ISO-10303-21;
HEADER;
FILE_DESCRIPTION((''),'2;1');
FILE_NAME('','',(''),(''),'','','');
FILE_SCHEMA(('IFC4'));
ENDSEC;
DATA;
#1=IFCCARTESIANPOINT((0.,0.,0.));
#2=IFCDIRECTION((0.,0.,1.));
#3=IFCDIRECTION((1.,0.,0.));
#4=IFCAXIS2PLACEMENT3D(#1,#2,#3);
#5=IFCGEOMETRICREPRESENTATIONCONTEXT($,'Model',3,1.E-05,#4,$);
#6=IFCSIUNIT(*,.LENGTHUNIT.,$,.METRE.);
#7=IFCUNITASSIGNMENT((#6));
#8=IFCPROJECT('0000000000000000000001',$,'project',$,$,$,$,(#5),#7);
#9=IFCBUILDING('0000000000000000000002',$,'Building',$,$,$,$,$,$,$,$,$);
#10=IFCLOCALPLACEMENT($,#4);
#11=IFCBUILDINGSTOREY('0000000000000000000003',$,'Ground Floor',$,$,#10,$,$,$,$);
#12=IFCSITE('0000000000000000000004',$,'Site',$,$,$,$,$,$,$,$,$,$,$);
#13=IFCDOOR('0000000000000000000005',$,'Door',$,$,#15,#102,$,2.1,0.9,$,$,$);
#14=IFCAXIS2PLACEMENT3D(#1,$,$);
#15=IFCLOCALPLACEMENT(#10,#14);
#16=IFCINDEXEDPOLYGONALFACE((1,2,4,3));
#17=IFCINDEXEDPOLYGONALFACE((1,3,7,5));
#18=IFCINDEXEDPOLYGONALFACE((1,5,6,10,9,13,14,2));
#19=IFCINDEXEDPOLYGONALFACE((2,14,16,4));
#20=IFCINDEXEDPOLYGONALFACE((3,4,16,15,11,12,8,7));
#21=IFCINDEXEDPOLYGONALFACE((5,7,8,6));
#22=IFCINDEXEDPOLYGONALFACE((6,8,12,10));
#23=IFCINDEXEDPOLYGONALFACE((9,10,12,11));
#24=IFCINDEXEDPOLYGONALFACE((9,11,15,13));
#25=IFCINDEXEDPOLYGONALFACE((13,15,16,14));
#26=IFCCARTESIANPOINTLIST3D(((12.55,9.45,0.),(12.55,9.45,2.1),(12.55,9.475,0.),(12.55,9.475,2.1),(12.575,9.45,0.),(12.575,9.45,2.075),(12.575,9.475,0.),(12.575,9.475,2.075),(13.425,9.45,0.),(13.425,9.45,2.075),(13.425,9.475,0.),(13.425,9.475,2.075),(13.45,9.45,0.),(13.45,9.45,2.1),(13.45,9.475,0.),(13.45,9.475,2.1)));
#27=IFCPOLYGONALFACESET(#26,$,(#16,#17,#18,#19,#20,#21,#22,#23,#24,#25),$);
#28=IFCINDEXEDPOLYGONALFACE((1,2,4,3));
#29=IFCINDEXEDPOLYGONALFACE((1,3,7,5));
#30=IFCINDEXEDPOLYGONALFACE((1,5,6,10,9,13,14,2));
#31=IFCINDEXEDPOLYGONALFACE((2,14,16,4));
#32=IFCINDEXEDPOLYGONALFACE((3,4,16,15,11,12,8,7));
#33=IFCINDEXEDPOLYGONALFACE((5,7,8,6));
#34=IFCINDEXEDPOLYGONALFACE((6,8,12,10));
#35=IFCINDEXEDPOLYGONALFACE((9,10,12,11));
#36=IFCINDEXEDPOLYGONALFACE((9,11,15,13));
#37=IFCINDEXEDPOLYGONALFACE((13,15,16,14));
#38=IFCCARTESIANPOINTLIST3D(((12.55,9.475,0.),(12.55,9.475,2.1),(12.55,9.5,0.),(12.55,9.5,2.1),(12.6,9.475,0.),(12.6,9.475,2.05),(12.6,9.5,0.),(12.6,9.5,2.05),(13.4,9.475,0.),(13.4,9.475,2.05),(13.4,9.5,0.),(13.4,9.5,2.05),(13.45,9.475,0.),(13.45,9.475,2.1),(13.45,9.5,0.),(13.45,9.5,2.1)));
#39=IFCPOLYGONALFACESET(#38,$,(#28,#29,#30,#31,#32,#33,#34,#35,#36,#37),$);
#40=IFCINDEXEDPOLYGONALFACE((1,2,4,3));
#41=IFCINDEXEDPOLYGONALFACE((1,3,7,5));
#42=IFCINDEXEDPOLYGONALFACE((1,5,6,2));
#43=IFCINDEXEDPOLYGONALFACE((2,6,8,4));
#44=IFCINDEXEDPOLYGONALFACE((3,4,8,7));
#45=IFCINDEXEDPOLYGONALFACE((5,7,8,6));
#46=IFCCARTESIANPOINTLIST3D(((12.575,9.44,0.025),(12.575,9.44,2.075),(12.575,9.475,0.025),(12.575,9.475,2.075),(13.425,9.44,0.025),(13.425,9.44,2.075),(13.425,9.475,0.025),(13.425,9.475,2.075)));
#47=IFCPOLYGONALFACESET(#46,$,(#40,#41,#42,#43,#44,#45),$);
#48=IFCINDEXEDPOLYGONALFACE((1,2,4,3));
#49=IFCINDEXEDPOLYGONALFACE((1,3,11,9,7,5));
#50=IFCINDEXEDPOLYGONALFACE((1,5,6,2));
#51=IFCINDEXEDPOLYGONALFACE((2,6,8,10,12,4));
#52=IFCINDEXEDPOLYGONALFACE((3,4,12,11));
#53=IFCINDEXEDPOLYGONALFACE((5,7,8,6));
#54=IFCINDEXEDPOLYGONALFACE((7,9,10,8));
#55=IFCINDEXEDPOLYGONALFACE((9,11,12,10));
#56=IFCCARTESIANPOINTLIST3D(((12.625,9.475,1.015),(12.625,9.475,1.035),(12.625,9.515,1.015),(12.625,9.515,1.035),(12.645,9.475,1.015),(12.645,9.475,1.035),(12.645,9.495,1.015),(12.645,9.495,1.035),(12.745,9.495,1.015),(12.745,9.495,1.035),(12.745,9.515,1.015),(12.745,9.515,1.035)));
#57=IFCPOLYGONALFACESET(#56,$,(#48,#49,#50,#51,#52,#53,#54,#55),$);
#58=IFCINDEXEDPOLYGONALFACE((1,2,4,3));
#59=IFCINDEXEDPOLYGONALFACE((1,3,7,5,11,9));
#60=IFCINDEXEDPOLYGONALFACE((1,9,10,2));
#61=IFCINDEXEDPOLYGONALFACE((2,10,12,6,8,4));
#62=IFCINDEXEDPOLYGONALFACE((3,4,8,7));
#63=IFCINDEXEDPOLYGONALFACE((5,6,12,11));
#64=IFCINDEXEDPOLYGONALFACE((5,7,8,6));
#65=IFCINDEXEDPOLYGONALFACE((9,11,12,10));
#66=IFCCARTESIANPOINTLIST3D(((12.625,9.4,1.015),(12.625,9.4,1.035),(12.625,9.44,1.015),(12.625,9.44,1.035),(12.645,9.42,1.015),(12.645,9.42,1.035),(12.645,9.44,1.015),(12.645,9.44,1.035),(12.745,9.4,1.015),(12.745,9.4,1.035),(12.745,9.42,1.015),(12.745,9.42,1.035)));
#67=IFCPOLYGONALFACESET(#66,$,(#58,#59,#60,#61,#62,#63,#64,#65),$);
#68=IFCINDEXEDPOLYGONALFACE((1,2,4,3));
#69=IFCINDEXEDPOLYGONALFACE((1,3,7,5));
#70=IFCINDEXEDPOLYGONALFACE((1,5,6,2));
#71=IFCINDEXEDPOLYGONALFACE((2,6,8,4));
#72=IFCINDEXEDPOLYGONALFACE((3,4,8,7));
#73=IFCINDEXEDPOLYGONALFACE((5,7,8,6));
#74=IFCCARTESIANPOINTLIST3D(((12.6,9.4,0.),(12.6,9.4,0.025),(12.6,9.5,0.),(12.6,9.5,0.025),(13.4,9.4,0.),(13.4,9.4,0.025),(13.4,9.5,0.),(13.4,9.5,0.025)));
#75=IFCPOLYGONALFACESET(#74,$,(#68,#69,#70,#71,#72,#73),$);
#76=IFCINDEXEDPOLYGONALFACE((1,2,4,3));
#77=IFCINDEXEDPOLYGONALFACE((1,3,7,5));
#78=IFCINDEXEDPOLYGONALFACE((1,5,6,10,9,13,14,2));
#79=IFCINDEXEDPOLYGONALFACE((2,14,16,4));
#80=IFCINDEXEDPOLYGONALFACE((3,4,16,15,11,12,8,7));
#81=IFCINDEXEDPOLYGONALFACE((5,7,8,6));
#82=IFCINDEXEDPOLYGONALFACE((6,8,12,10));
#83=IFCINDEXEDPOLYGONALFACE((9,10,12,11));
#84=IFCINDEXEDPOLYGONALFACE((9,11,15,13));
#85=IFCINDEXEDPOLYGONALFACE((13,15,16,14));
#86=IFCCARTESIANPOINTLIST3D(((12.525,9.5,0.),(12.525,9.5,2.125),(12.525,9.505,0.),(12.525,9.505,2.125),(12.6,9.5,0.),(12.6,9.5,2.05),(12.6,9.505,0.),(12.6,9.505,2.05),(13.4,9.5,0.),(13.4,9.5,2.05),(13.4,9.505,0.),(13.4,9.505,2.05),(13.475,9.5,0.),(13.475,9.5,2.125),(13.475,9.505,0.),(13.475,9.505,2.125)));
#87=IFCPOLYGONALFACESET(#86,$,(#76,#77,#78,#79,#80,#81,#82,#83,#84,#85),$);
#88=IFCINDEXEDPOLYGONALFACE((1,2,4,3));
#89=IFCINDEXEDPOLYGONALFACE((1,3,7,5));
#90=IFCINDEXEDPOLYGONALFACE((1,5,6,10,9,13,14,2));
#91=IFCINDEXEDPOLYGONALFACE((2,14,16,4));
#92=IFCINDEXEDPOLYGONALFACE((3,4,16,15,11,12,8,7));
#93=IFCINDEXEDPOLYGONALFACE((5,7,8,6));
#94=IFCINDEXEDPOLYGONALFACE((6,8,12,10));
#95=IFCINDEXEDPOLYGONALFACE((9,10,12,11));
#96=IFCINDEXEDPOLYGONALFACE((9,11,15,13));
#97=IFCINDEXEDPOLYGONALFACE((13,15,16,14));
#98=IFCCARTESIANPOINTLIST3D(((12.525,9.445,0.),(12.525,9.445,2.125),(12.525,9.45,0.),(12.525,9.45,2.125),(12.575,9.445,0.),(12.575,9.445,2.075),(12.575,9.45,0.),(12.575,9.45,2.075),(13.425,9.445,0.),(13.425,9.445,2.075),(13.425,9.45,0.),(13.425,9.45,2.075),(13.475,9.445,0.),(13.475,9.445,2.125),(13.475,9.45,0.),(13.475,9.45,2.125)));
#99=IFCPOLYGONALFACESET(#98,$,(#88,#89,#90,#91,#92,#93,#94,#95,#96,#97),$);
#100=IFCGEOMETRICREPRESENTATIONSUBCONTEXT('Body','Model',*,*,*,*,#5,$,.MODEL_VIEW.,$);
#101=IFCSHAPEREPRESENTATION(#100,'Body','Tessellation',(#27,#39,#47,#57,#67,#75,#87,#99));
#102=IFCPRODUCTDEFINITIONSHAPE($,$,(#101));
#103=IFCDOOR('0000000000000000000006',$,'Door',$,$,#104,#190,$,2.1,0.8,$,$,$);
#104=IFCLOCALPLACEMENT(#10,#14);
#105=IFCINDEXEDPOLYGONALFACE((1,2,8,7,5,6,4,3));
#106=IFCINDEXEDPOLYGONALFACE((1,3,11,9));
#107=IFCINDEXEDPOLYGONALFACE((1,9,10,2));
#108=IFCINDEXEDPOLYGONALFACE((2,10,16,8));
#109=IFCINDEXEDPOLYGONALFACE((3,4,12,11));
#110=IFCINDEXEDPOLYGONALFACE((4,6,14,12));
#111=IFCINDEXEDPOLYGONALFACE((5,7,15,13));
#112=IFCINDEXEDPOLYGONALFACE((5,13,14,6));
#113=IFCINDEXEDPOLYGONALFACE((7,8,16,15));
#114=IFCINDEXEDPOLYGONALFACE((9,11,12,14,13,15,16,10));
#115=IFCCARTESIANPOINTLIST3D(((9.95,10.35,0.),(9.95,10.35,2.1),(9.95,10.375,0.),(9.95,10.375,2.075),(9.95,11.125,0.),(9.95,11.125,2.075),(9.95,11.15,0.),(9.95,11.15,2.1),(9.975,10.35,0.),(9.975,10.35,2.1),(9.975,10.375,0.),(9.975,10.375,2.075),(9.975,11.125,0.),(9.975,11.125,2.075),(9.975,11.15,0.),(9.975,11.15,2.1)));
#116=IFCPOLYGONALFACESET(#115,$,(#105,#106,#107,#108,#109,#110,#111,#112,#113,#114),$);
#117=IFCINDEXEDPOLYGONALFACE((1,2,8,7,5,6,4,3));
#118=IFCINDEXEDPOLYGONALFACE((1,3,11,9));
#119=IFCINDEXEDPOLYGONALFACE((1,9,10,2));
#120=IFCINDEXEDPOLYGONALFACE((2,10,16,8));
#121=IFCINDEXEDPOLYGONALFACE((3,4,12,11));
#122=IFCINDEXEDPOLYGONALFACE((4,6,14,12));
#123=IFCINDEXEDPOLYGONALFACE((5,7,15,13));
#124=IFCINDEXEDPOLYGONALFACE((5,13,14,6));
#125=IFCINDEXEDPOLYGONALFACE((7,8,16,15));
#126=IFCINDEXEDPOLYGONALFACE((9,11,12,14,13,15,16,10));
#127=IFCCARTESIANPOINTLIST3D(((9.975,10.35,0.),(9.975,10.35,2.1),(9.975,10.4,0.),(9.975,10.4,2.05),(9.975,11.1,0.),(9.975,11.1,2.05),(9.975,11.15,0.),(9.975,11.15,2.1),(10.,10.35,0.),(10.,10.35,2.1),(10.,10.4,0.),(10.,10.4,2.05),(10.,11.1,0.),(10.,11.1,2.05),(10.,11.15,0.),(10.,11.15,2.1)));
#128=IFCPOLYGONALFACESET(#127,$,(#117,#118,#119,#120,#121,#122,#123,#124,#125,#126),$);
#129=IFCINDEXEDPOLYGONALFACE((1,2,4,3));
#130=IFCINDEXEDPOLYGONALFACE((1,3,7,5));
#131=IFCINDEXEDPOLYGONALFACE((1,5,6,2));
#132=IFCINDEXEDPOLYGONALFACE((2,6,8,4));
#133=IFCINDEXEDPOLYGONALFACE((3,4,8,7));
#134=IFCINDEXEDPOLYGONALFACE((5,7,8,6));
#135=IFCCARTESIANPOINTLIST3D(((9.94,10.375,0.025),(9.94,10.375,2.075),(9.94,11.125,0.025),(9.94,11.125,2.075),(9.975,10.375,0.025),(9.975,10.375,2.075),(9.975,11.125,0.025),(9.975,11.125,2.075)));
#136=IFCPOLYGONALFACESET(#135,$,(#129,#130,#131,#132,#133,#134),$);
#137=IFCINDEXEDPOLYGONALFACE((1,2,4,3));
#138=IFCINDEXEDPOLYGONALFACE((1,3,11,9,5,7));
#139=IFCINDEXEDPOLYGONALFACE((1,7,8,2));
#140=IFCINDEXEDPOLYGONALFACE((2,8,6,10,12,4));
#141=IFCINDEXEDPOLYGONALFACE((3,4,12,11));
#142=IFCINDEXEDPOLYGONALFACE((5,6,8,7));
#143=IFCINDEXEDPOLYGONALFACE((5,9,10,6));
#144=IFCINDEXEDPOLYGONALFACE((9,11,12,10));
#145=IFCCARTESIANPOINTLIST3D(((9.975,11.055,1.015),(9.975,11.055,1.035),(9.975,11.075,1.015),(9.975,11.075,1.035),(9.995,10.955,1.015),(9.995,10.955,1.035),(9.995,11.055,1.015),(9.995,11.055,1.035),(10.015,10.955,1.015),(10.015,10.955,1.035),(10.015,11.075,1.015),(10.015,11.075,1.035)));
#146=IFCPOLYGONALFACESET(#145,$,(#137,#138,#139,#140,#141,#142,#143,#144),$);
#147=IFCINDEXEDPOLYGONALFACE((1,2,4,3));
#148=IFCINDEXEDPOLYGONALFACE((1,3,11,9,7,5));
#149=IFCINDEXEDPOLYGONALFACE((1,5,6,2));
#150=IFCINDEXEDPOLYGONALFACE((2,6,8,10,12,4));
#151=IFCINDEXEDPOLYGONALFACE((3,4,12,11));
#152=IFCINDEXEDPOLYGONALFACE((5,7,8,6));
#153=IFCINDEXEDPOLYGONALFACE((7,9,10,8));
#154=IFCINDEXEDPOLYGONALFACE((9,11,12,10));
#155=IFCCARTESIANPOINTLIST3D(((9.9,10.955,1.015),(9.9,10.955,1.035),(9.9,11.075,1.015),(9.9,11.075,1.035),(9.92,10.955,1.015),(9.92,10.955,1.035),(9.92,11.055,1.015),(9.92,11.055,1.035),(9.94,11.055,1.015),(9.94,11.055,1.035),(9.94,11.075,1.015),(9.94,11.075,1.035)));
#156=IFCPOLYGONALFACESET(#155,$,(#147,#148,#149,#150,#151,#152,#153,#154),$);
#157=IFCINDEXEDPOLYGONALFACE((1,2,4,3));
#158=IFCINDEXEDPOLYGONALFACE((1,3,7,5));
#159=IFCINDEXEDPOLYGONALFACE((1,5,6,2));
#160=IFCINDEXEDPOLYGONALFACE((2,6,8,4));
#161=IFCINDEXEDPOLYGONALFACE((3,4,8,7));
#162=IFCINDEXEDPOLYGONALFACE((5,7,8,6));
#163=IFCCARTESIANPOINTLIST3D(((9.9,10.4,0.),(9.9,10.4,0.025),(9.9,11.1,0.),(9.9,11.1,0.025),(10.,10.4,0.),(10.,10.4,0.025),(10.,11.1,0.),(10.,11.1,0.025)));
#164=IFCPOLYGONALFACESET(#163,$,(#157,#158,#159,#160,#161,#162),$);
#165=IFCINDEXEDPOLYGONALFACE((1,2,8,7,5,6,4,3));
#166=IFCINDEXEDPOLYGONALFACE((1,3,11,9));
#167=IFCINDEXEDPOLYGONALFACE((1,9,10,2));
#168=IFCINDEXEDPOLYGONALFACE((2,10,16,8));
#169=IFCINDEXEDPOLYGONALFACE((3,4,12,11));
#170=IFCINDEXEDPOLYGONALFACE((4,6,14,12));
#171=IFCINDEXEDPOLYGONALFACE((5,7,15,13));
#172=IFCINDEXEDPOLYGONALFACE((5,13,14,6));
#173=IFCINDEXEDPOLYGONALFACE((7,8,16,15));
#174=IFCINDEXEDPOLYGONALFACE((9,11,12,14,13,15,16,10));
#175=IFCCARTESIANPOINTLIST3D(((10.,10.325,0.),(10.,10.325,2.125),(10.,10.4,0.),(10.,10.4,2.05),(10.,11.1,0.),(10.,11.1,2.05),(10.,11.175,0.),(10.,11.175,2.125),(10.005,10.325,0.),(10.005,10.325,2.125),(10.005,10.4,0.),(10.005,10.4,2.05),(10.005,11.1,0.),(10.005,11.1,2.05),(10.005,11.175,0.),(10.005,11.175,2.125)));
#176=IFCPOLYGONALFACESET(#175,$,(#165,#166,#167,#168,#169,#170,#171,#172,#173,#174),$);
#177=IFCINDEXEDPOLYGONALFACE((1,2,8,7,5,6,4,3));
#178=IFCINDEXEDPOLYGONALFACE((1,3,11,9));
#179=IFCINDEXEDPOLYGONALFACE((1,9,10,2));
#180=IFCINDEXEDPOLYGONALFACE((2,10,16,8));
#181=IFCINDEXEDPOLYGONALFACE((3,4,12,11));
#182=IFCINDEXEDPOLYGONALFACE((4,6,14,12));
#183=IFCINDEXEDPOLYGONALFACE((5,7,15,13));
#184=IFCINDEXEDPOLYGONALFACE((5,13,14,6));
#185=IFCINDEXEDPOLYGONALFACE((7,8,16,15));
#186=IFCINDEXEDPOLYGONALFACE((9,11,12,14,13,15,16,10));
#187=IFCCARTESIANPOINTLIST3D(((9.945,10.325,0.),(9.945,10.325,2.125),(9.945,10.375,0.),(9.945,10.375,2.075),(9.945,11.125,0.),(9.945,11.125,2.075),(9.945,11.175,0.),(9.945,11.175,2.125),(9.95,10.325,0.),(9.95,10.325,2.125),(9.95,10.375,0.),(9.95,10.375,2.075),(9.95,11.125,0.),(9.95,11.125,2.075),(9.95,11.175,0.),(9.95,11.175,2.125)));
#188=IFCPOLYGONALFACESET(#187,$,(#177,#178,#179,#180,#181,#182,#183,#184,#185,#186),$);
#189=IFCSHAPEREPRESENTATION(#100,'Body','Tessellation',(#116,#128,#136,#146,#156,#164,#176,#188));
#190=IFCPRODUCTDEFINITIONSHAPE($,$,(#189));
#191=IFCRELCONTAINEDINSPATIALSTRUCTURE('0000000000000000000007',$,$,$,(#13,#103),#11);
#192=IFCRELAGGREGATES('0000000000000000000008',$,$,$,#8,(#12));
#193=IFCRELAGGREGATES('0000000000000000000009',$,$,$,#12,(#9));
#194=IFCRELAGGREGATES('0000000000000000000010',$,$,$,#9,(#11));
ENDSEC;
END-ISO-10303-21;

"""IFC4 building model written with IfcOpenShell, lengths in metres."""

from ifc_helpers import new_model, si_unit, frame, origin_with_axes, place, context, subcontext, project, spatial, line, indexed_curve, outline, extrude, element, save


model = new_model("IFC4")

# Units and contexts
model_context = context("Model", 3, precision=1e-05, world=origin_with_axes())
body_context = subcontext(model_context, "Body", "Model", "MODEL_VIEW")
ifc_project = project(units=[si_unit("LENGTHUNIT", "METRE")], contexts=[model_context])

# Site, building, storey
site = spatial("IfcSite", under=ifc_project, Name="Site")
building = spatial("IfcBuilding", under=site, Name="Building")
storey_placement = place(None, origin_with_axes())
storey = spatial("IfcBuildingStorey", under=building, at=storey_placement, Name="Ground Floor")

# Doors
door_1_placement = place(storey_placement, frame((13.45, 9.5, 0.0), z_axis=(0.0, 0.0, 1.0), x_axis=(-1.0, 0.0, 0.0)))
element("IfcDoor", 1, at=door_1_placement, inside=storey, Name="Door", OverallHeight=2.1, OverallWidth=0.9, context=body_context, shape_type="SweptSolid", body=[
    extrude(outline(indexed_curve([(0.0, 0.0), (0.0, 2.1), (0.9, 2.1), (0.9, 0.0), (0.875, 0.0), (0.875, 2.075), (0.025, 2.075), (0.025, 0.0)], segments=[line(1, 2, 3, 4, 5, 6, 7, 8, 1)])), frame((0.0, 0.025, 0.0), z_axis=(0.0, -1.0, 0.0), x_axis=(1.0, 0.0, 0.0)), (0.0, 0.0, -1.0), 0.025),
    extrude(outline(indexed_curve([(0.0, 0.0), (0.0, 2.1), (0.9, 2.1), (0.9, 0.0), (0.85, 0.0), (0.85, 2.05), (0.05, 2.05), (0.05, 0.0)], segments=[line(1, 2, 3, 4, 5, 6, 7, 8, 1)])), frame((0.0, 0.0, 0.0), z_axis=(0.0, -1.0, 0.0), x_axis=(1.0, 0.0, 0.0)), (0.0, 0.0, -1.0), 0.025),
    extrude(outline(indexed_curve([(0.0, 0.0), (0.85, 0.0), (0.85, 0.035), (0.0, 0.035)], segments=[line(1, 2, 3, 4, 1)])), frame((0.025, 0.025, 0.025), z_axis=(0.0, 0.0, 1.0), x_axis=(1.0, 0.0, 0.0)), (0.0, 0.0, 1.0), 2.05),
    extrude(outline(indexed_curve([(0.0, 0.0), (0.0, -0.04), (-0.12, -0.04), (-0.12, -0.02), (-0.02, -0.02), (-0.02, 0.0)], segments=[line(1, 2, 3, 4, 5, 6, 1)])), frame((0.825, 0.025, 1.015), z_axis=(0.0, 0.0, 1.0), x_axis=(1.0, 0.0, 0.0)), (0.0, 0.0, 1.0), 0.02),
    extrude(outline(indexed_curve([(0.0, 0.0), (0.0, 0.04), (-0.12, 0.04), (-0.12, 0.02), (-0.02, 0.02), (-0.02, 0.0)], segments=[line(1, 2, 3, 4, 5, 6, 1)])), frame((0.825, 0.06, 1.015), z_axis=(0.0, 0.0, 1.0), x_axis=(1.0, 0.0, 0.0)), (0.0, 0.0, 1.0), 0.02),
    extrude(outline(indexed_curve([(0.0, 0.0), (0.8, 0.0), (0.8, 0.1), (0.0, 0.1)], segments=[line(1, 2, 3, 4, 1)])), frame((0.05, 0.0, 0.0), z_axis=(0.0, 0.0, 1.0), x_axis=(1.0, 0.0, 0.0)), (0.0, 0.0, 1.0), 0.025),
    extrude(outline(indexed_curve([(0.0, 0.0), (0.0, 2.125), (0.95, 2.125), (0.95, 0.0), (0.875, 0.0), (0.875, 2.05), (0.075, 2.05), (0.075, 0.0)], segments=[line(1, 2, 3, 4, 5, 6, 7, 8, 1)])), frame((-0.025, -0.005, 0.0), z_axis=(0.0, -1.0, 0.0), x_axis=(1.0, 0.0, 0.0)), (0.0, 0.0, -1.0), 0.005),
    extrude(outline(indexed_curve([(0.0, 0.0), (0.0, 2.125), (0.95, 2.125), (0.95, 0.0), (0.9, 0.0), (0.9, 2.075), (0.05, 2.075), (0.05, 0.0)], segments=[line(1, 2, 3, 4, 5, 6, 7, 8, 1)])), frame((-0.025, 0.05, 0.0), z_axis=(0.0, -1.0, 0.0), x_axis=(1.0, 0.0, 0.0)), (0.0, 0.0, -1.0), 0.005),
])
door_2_placement = place(storey_placement, frame((10.0, 10.35, 0.0), z_axis=(0.0, 0.0, 1.0), x_axis=(0.0, 1.0, 0.0)))
element("IfcDoor", 2, at=door_2_placement, inside=storey, Name="Door", OverallHeight=2.1, OverallWidth=0.8, context=body_context, shape_type="SweptSolid", body=[
    extrude(outline(indexed_curve([(0.0, 0.0), (0.0, 2.1), (0.8, 2.1), (0.8, 0.0), (0.775, 0.0), (0.775, 2.075), (0.025, 2.075), (0.025, 0.0)], segments=[line(1, 2, 3, 4, 5, 6, 7, 8, 1)])), frame((0.0, 0.025, 0.0), z_axis=(0.0, -1.0, 0.0), x_axis=(1.0, 0.0, 0.0)), (0.0, 0.0, -1.0), 0.025),
    extrude(outline(indexed_curve([(0.0, 0.0), (0.0, 2.1), (0.8, 2.1), (0.8, 0.0), (0.75, 0.0), (0.75, 2.05), (0.05, 2.05), (0.05, 0.0)], segments=[line(1, 2, 3, 4, 5, 6, 7, 8, 1)])), frame((0.0, 0.0, 0.0), z_axis=(0.0, -1.0, 0.0), x_axis=(1.0, 0.0, 0.0)), (0.0, 0.0, -1.0), 0.025),
    extrude(outline(indexed_curve([(0.0, 0.0), (0.75, 0.0), (0.75, 0.035), (0.0, 0.035)], segments=[line(1, 2, 3, 4, 1)])), frame((0.025, 0.025, 0.025), z_axis=(0.0, 0.0, 1.0), x_axis=(1.0, 0.0, 0.0)), (0.0, 0.0, 1.0), 2.05),
    extrude(outline(indexed_curve([(0.0, 0.0), (0.0, -0.04), (-0.12, -0.04), (-0.12, -0.02), (-0.02, -0.02), (-0.02, 0.0)], segments=[line(1, 2, 3, 4, 5, 6, 1)])), frame((0.725, 0.025, 1.015), z_axis=(0.0, 0.0, 1.0), x_axis=(1.0, 0.0, 0.0)), (0.0, 0.0, 1.0), 0.02),
    extrude(outline(indexed_curve([(0.0, 0.0), (0.0, 0.04), (-0.12, 0.04), (-0.12, 0.02), (-0.02, 0.02), (-0.02, 0.0)], segments=[line(1, 2, 3, 4, 5, 6, 1)])), frame((0.725, 0.06, 1.015), z_axis=(0.0, 0.0, 1.0), x_axis=(1.0, 0.0, 0.0)), (0.0, 0.0, 1.0), 0.02),
    extrude(outline(indexed_curve([(0.0, 0.0), (0.7, 0.0), (0.7, 0.1), (0.0, 0.1)], segments=[line(1, 2, 3, 4, 1)])), frame((0.05, 0.0, 0.0), z_axis=(0.0, 0.0, 1.0), x_axis=(1.0, 0.0, 0.0)), (0.0, 0.0, 1.0), 0.025),
    extrude(outline(indexed_curve([(0.0, 0.0), (0.0, 2.125), (0.85, 2.125), (0.85, 0.0), (0.775, 0.0), (0.775, 2.05), (0.075, 2.05), (0.075, 0.0)], segments=[line(1, 2, 3, 4, 5, 6, 7, 8, 1)])), frame((-0.025, -0.005, 0.0), z_axis=(0.0, -1.0, 0.0), x_axis=(1.0, 0.0, 0.0)), (0.0, 0.0, -1.0), 0.005),
    extrude(outline(indexed_curve([(0.0, 0.0), (0.0, 2.125), (0.85, 2.125), (0.85, 0.0), (0.8, 0.0), (0.8, 2.075), (0.05, 2.075), (0.05, 0.0)], segments=[line(1, 2, 3, 4, 5, 6, 7, 8, 1)])), frame((-0.025, 0.05, 0.0), z_axis=(0.0, -1.0, 0.0), x_axis=(1.0, 0.0, 0.0)), (0.0, 0.0, -1.0), 0.005),
])

save(model, "model.ifc")
